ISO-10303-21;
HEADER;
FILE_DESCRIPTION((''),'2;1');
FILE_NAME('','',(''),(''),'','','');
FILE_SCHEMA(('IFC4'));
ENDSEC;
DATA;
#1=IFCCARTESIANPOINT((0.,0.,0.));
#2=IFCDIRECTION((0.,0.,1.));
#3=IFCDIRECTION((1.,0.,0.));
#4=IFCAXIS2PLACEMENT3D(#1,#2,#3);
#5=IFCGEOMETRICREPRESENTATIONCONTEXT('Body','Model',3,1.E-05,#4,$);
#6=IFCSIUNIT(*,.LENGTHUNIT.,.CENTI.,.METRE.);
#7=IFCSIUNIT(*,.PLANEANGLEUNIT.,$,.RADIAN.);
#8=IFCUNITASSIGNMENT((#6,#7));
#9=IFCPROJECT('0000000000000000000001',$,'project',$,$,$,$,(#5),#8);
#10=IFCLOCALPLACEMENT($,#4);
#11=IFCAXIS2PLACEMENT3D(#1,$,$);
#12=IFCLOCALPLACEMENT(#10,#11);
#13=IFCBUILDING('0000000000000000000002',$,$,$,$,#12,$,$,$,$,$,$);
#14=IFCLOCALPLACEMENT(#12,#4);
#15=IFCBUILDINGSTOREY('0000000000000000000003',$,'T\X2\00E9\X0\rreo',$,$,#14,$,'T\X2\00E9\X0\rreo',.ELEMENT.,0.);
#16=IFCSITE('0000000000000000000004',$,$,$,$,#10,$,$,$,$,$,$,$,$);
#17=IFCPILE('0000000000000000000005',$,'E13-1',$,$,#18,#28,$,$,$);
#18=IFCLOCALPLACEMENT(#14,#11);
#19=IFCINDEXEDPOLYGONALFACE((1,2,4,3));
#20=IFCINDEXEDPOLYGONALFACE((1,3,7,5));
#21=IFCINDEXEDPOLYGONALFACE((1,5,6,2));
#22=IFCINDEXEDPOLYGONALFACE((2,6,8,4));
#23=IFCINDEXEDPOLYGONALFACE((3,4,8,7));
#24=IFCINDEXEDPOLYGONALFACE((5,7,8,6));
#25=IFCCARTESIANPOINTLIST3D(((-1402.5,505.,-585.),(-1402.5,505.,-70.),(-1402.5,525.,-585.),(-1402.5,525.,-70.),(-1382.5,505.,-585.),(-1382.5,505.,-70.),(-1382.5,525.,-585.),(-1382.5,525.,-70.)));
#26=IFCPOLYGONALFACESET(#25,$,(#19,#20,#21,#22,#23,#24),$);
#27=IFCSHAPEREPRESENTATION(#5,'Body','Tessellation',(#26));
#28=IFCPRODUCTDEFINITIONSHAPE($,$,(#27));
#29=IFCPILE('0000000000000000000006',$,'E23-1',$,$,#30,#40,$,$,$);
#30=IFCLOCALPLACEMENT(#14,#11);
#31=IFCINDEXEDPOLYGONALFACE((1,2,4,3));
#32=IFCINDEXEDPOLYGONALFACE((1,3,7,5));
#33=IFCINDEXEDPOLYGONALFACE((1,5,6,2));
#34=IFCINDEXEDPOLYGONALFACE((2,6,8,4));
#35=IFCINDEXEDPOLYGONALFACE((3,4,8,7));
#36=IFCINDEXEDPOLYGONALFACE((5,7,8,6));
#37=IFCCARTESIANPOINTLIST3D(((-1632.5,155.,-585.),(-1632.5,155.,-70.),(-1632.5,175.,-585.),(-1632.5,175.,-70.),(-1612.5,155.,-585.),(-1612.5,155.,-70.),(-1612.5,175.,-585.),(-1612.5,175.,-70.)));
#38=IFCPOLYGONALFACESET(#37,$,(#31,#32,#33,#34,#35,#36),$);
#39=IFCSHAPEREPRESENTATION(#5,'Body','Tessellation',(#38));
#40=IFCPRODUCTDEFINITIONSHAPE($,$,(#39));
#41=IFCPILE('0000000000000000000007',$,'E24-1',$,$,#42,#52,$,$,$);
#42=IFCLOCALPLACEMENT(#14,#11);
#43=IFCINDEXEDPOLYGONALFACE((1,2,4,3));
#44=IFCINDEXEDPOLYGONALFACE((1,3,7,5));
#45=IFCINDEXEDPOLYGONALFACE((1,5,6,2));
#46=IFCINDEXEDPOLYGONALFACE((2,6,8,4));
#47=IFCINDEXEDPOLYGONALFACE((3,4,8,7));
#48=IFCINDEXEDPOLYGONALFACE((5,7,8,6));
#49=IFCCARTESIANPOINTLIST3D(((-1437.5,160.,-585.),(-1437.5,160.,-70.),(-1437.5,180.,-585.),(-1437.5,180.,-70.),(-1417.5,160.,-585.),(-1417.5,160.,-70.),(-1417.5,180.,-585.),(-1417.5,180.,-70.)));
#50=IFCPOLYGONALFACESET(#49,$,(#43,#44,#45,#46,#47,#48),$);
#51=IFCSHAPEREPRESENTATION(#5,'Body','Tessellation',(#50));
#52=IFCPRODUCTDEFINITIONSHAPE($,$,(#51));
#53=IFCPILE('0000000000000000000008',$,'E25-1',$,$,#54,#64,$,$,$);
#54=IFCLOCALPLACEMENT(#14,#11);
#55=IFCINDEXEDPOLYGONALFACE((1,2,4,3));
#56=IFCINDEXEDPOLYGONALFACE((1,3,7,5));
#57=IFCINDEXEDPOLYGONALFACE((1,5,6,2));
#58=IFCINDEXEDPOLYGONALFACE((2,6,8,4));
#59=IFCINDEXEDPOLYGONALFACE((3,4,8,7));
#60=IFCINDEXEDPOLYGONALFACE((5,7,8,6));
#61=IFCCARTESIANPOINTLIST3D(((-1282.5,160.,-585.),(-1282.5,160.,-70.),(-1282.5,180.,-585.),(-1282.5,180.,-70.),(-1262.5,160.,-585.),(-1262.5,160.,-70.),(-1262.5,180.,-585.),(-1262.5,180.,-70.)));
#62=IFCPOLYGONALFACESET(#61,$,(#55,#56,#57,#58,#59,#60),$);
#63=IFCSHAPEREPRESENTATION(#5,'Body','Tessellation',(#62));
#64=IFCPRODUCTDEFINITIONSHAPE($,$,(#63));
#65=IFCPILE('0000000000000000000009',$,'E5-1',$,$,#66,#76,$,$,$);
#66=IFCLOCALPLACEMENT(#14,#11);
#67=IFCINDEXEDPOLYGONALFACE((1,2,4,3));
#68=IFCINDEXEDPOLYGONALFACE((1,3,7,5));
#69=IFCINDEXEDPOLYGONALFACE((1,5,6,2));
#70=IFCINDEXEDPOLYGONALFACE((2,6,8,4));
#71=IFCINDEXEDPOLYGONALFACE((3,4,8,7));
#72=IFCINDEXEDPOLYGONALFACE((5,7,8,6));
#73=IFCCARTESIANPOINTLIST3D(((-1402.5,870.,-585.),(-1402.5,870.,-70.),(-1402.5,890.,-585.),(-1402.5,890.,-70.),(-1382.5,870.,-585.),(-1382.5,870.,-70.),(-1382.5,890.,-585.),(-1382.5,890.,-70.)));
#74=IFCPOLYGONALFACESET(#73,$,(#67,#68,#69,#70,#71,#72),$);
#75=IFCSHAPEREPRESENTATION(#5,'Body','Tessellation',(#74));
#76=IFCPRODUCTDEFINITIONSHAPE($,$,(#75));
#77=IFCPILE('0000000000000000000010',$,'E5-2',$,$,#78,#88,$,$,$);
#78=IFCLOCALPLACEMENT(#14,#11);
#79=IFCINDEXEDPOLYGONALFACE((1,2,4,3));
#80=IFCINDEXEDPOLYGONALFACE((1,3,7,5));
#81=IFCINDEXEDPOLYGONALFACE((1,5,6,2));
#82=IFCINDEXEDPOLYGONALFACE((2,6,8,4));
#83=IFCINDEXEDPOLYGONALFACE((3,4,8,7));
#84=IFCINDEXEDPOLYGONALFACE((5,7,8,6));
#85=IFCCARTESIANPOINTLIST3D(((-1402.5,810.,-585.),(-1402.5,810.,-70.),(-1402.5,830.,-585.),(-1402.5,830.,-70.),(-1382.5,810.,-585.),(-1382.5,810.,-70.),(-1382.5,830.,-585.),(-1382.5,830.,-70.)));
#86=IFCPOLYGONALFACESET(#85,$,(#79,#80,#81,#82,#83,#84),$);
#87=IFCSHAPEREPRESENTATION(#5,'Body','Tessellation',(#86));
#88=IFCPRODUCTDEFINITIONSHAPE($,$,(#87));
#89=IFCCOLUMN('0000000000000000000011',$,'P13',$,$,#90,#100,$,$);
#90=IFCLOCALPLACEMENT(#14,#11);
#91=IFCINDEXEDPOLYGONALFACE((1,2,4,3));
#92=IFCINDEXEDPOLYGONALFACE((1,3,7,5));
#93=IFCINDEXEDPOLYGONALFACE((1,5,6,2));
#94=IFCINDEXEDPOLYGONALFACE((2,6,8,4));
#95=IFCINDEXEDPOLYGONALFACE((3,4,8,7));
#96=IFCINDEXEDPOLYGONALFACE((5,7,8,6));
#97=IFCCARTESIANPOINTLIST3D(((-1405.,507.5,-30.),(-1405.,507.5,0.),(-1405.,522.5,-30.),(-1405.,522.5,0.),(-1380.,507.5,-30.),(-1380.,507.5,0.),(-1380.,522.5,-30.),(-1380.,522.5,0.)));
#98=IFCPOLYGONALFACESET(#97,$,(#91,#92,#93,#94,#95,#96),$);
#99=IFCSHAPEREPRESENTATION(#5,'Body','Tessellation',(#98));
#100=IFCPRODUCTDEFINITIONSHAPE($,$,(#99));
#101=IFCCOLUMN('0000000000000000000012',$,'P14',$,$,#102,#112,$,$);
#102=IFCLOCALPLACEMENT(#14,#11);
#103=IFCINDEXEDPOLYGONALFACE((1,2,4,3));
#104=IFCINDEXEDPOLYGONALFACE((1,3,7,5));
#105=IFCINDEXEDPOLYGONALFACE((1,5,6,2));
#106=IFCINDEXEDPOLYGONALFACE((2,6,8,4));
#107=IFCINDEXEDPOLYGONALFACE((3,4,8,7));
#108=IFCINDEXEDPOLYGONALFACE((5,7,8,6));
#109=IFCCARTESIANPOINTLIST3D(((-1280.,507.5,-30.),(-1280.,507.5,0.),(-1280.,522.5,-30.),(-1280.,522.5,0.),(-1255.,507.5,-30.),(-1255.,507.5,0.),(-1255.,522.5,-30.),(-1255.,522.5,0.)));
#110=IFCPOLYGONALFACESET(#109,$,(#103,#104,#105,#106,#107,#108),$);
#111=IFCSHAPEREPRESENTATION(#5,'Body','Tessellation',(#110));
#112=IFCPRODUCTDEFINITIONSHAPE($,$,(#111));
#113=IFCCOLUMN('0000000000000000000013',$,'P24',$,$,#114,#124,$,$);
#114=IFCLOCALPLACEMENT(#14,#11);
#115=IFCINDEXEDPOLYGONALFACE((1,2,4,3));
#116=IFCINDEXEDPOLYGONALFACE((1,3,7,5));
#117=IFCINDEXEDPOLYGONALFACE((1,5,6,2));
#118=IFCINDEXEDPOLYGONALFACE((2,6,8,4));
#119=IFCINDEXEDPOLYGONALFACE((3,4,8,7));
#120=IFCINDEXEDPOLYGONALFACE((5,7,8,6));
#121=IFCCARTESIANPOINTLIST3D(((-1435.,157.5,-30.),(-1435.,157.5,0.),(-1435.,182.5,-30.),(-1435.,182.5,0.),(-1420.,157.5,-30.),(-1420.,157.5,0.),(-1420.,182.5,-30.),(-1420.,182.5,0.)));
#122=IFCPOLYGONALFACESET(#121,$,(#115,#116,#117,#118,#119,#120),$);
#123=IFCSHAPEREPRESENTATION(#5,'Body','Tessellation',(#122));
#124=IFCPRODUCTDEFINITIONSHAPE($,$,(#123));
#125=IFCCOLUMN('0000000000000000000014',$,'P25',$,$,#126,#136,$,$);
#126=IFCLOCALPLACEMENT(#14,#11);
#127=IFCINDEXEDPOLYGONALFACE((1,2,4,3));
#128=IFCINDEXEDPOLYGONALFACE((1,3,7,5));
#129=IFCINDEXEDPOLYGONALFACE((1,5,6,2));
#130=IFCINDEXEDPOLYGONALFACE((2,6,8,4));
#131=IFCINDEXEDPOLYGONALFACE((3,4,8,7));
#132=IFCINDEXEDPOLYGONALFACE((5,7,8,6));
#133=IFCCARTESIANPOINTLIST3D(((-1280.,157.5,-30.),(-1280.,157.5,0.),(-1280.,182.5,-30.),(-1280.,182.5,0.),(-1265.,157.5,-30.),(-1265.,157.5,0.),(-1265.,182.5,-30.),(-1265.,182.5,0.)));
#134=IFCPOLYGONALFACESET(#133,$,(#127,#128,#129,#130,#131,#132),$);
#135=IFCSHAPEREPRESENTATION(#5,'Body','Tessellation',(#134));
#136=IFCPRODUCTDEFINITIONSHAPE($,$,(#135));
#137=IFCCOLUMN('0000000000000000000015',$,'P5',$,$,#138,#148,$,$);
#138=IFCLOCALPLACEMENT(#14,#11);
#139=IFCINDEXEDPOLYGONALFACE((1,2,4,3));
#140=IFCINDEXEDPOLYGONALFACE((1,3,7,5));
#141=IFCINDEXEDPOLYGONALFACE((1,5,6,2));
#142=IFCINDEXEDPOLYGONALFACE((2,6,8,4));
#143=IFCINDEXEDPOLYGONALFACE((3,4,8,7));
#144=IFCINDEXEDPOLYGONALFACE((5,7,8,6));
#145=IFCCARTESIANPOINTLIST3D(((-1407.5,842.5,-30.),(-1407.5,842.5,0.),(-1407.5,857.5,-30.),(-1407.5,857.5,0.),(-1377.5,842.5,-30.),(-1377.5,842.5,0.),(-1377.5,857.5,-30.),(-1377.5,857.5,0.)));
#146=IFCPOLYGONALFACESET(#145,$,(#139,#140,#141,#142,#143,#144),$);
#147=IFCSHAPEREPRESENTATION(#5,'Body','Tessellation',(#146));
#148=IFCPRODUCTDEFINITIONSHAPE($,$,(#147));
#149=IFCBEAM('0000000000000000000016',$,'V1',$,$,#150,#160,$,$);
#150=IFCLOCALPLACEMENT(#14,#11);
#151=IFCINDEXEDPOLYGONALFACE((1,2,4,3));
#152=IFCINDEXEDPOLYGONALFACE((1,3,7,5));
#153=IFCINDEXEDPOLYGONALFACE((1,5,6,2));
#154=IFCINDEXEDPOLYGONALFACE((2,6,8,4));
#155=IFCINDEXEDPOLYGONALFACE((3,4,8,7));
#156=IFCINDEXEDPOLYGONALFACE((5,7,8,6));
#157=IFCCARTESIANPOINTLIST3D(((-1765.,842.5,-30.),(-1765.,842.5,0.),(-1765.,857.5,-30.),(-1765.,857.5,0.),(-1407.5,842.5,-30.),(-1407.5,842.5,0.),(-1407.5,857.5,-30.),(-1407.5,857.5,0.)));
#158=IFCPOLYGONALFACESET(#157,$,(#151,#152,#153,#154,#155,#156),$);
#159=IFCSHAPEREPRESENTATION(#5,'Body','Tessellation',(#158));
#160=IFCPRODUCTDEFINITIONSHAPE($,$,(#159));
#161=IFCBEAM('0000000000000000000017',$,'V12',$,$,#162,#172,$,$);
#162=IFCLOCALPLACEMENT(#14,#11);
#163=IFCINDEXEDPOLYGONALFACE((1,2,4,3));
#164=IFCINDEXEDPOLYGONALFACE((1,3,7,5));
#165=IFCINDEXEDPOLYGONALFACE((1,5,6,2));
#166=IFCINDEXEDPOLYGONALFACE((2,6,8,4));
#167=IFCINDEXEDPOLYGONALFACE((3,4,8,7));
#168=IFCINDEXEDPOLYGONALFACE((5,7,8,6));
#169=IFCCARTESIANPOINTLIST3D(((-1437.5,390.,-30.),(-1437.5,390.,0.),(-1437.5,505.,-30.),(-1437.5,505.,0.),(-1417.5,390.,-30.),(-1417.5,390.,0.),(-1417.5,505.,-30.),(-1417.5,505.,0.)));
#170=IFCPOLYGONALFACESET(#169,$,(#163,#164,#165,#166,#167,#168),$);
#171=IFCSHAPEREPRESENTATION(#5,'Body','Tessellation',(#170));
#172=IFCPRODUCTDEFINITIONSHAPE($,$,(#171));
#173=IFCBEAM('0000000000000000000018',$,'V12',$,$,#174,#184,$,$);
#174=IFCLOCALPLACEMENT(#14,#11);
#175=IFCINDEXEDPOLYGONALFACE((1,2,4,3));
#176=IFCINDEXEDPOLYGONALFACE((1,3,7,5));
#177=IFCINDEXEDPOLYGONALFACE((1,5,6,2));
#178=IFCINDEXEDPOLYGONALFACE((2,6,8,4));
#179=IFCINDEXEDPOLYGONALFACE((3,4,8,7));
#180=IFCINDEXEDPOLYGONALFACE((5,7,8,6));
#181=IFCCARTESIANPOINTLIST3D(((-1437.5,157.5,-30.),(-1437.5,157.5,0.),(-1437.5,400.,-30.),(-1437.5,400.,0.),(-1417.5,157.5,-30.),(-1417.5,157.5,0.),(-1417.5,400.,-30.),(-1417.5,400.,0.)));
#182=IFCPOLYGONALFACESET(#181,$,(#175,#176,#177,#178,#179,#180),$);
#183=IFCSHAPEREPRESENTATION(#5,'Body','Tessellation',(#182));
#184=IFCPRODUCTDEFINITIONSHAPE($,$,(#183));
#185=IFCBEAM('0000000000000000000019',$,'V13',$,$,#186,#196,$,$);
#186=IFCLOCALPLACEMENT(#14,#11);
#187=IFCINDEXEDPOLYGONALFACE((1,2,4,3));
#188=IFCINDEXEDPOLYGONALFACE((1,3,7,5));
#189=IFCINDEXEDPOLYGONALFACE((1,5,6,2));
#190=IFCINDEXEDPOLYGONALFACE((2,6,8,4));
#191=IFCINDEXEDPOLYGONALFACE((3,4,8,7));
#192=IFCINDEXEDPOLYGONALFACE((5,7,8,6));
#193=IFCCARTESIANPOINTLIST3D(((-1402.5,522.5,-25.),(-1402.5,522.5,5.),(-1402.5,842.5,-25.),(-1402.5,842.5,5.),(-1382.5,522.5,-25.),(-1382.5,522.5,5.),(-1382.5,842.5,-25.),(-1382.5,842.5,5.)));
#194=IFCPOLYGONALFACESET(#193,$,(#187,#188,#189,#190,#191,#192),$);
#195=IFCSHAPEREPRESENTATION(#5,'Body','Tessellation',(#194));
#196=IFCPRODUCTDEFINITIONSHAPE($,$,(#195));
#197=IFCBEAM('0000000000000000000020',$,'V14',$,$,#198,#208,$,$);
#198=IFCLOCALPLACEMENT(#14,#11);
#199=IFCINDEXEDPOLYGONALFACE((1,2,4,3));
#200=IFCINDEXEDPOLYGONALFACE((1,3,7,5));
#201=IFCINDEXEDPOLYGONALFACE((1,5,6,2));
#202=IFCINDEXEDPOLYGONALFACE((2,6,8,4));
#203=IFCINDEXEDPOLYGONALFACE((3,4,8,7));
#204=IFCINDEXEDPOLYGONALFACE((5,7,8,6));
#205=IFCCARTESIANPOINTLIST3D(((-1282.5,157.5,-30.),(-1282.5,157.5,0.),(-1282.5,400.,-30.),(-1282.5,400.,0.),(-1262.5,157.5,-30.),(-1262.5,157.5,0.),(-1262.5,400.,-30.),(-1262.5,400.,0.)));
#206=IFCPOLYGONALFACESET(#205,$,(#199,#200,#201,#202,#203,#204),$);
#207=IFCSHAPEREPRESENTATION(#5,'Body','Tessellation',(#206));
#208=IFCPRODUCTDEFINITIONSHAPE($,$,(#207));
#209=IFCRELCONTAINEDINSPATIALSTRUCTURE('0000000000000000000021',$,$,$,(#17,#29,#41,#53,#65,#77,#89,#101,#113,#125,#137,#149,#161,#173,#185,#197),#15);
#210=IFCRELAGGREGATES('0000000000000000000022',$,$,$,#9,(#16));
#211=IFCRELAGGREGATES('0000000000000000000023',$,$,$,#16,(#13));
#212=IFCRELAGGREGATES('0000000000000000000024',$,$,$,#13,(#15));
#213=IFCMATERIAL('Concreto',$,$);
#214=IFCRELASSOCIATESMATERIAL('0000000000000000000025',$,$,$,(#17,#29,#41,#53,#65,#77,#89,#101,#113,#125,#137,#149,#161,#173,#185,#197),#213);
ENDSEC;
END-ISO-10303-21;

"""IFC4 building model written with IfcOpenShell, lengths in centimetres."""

from ifc_helpers import new_model, si_unit, frame, origin, origin_with_axes, origin_2d_with_axis, place, context, project, spatial, rectangle, extrude, material, element, save


model = new_model("IFC4")

# Units and contexts
model_context = context("Model", 3, precision=1e-05, world=origin_with_axes(), identifier="Body")
ifc_project = project(units=[si_unit("LENGTHUNIT", "METRE", prefix="CENTI"), si_unit("PLANEANGLEUNIT", "RADIAN")], contexts=[model_context])

# Site, building, storey
site_placement = place(None, origin_with_axes())
site = spatial("IfcSite", under=ifc_project, at=site_placement)
building_placement = place(site_placement, origin())
building = spatial("IfcBuilding", under=site, at=building_placement)
storey_placement = place(building_placement, origin_with_axes())
storey = spatial("IfcBuildingStorey", under=building, at=storey_placement, Name="Térreo", LongName="Térreo", CompositionType="ELEMENT", Elevation=0.0)

# Piles
ifc_material = material(Name="Concreto")
for number, where, z_axis, x_axis, name in (
    (1, (-1392.5, 515.0, -70.0), (0.0, 0.0, 1.0), (1.0, 0.0, 0.0), "E13-1"),
    (2, (-1622.5, 165.0, -70.0), (0.0, 0.0, 1.0), (1.0, 0.0, 0.0), "E23-1"),
):
    element("IfcPile", number, at=place(storey_placement, frame(where, z_axis=z_axis, x_axis=x_axis)), inside=storey, material=ifc_material, Name=name, context=model_context, shape_type="SweptSolid", body=[
        extrude(rectangle(XDim=20.0, YDim=20.0, at=origin_2d_with_axis()), frame((0.0, 0.0, -515.0), z_axis=(0.0, 0.0, 1.0), x_axis=(0.0, 1.0, 0.0)), (0.0, 0.0, 1.0), 515.0),
    ])
pile_1_placement = place(storey_placement, frame((-1427.5, 170.0, -70.0), z_axis=(0.0, 0.0, 1.0), x_axis=(1.0, 0.0, 0.0)))
element("IfcPile", 3, at=pile_1_placement, inside=storey, material=ifc_material, Name="E24-1", context=model_context, shape_type="SweptSolid", body=[
    extrude(rectangle(XDim=20.0, YDim=20.0, at=origin_2d_with_axis()), frame((0.0, 0.0, -515.0), z_axis=(0.0, 0.0, 1.0), x_axis=(1.0, 0.0, 0.0)), (0.0, 0.0, 1.0), 515.0),
])
pile_2_placement = place(storey_placement, frame((-1272.5, 170.0, -70.0), z_axis=(0.0, 0.0, 1.0), x_axis=(1.0, 0.0, 0.0)))
element("IfcPile", 4, at=pile_2_placement, inside=storey, material=ifc_material, Name="E25-1", context=model_context, shape_type="SweptSolid", body=[
    extrude(rectangle(XDim=20.0, YDim=20.0, at=origin_2d_with_axis()), frame((0.0, 0.0, -515.0), z_axis=(0.0, 0.0, 1.0), x_axis=(-1.0, 0.0, 0.0)), (0.0, 0.0, 1.0), 515.0),
])
for number, where, z_axis, x_axis, name in (
    (5, (-1392.5, 880.0, -70.0), (0.0, 0.0, 1.0), (1.0, 0.0, 0.0), "E5-1"),
    (6, (-1392.5, 820.0, -70.0), (0.0, 0.0, 1.0), (1.0, 0.0, 0.0), "E5-2"),
):
    element("IfcPile", number, at=place(storey_placement, frame(where, z_axis=z_axis, x_axis=x_axis)), inside=storey, material=ifc_material, Name=name, context=model_context, shape_type="SweptSolid", body=[
        extrude(rectangle(XDim=20.0, YDim=20.0, at=origin_2d_with_axis()), frame((0.0, 0.0, -515.0), z_axis=(0.0, 0.0, 1.0), x_axis=(0.0, 1.0, 0.0)), (0.0, 0.0, 1.0), 515.0),
    ])

# Columns
for number, where, z_axis, x_axis, name in (
    (7, (-1392.5, 515.0, 0.0), (0.0, 0.0, 1.0), (1.0, 0.0, 0.0), "P13"),
    (8, (-1267.5, 515.0, 0.0), (0.0, 0.0, 1.0), (1.0, 0.0, 0.0), "P14"),
):
    element("IfcColumn", number, at=place(storey_placement, frame(where, z_axis=z_axis, x_axis=x_axis)), inside=storey, material=ifc_material, Name=name, context=model_context, shape_type="SolidModel", body=[
        extrude(rectangle(XDim=15.0, YDim=25.0, at=origin_2d_with_axis()), frame((0.0, 0.0, -30.0), z_axis=(0.0, 0.0, 1.0), x_axis=(0.0, 1.0, 0.0)), (0.0, 0.0, 1.0), 30.0),
    ])
column_1_placement = place(storey_placement, frame((-1427.5, 170.0, 0.0), z_axis=(0.0, 0.0, 1.0), x_axis=(1.0, 0.0, 0.0)))
element("IfcColumn", 9, at=column_1_placement, inside=storey, material=ifc_material, Name="P24", context=model_context, shape_type="SolidModel", body=[
    extrude(rectangle(XDim=15.0, YDim=25.0, at=origin_2d_with_axis()), frame((0.0, 0.0, -30.0), z_axis=(0.0, 0.0, 1.0), x_axis=(1.0, 0.0, 0.0)), (0.0, 0.0, 1.0), 30.0),
])
column_2_placement = place(storey_placement, frame((-1272.5, 170.0, 0.0), z_axis=(0.0, 0.0, 1.0), x_axis=(1.0, 0.0, 0.0)))
element("IfcColumn", 10, at=column_2_placement, inside=storey, material=ifc_material, Name="P25", context=model_context, shape_type="SolidModel", body=[
    extrude(rectangle(XDim=15.0, YDim=25.0, at=origin_2d_with_axis()), frame((0.0, 0.0, -30.0), z_axis=(0.0, 0.0, 1.0), x_axis=(-1.0, 0.0, 0.0)), (0.0, 0.0, 1.0), 30.0),
])
column_3_placement = place(storey_placement, frame((-1392.5, 850.0, 0.0), z_axis=(0.0, 0.0, 1.0), x_axis=(1.0, 0.0, 0.0)))
element("IfcColumn", 11, at=column_3_placement, inside=storey, material=ifc_material, Name="P5", context=model_context, shape_type="SolidModel", body=[
    extrude(rectangle(XDim=15.0, YDim=30.0, at=origin_2d_with_axis()), frame((0.0, 0.0, -30.0), z_axis=(0.0, 0.0, 1.0), x_axis=(0.0, 1.0, 0.0)), (0.0, 0.0, 1.0), 30.0),
])

# Beams
beam_1_placement = place(storey_placement, frame((-1586.25, 850.0, 0.0), z_axis=(0.0, 0.0, 1.0), x_axis=(1.0, 0.0, 0.0)))
element("IfcBeam", 12, at=beam_1_placement, inside=storey, material=ifc_material, Name="V1", context=model_context, shape_type="SolidModel", body=[
    extrude(rectangle(XDim=15.0, YDim=30.0, at=origin_2d_with_axis()), frame((-178.75, 0.0, -15.0), z_axis=(1.0, 0.0, 0.0), x_axis=(0.0, -1.0, 0.0)), (0.0, 0.0, 1.0), 357.5),
])
beam_2_placement = place(storey_placement, frame((-1427.5, 447.5, 0.0), z_axis=(0.0, 0.0, 1.0), x_axis=(1.0, 0.0, 0.0)))
element("IfcBeam", 13, at=beam_2_placement, inside=storey, material=ifc_material, Name="V12", context=model_context, shape_type="SolidModel", body=[
    extrude(rectangle(XDim=20.0, YDim=30.0, at=origin_2d_with_axis()), frame((0.0, -57.5, -15.0), z_axis=(0.0, 1.0, 0.0), x_axis=(-1.0, 0.0, 0.0)), (0.0, 0.0, 1.0), 115.0),
])
beam_3_placement = place(storey_placement, frame((-1427.5, 278.75, 0.0), z_axis=(0.0, 0.0, 1.0), x_axis=(1.0, 0.0, 0.0)))
element("IfcBeam", 14, at=beam_3_placement, inside=storey, material=ifc_material, Name="V12", context=model_context, shape_type="SolidModel", body=[
    extrude(rectangle(XDim=20.0, YDim=30.0, at=origin_2d_with_axis()), frame((0.0, -121.25, -15.0), z_axis=(0.0, 1.0, 0.0), x_axis=(-1.0, 0.0, 0.0)), (0.0, 0.0, 1.0), 242.5),
])
beam_4_placement = place(storey_placement, frame((-1392.5, 682.5, 5.0), z_axis=(0.0, 0.0, 1.0), x_axis=(1.0, 0.0, 0.0)))
element("IfcBeam", 15, at=beam_4_placement, inside=storey, material=ifc_material, Name="V13", context=model_context, shape_type="SolidModel", body=[
    extrude(rectangle(XDim=20.0, YDim=30.0, at=origin_2d_with_axis()), frame((0.0, -160.0, -15.0), z_axis=(0.0, 1.0, 0.0), x_axis=(-1.0, 0.0, 0.0)), (0.0, 0.0, 1.0), 320.0),
])
beam_5_placement = place(storey_placement, frame((-1272.5, 278.75, 0.0), z_axis=(0.0, 0.0, 1.0), x_axis=(1.0, 0.0, 0.0)))
element("IfcBeam", 16, at=beam_5_placement, inside=storey, material=ifc_material, Name="V14", context=model_context, shape_type="SolidModel", body=[
    extrude(rectangle(XDim=20.0, YDim=30.0, at=origin_2d_with_axis()), frame((0.0, -121.25, -15.0), z_axis=(0.0, 1.0, 0.0), x_axis=(-1.0, 0.0, 0.0)), (0.0, 0.0, 1.0), 242.5),
])

save(model, "model.ifc")
